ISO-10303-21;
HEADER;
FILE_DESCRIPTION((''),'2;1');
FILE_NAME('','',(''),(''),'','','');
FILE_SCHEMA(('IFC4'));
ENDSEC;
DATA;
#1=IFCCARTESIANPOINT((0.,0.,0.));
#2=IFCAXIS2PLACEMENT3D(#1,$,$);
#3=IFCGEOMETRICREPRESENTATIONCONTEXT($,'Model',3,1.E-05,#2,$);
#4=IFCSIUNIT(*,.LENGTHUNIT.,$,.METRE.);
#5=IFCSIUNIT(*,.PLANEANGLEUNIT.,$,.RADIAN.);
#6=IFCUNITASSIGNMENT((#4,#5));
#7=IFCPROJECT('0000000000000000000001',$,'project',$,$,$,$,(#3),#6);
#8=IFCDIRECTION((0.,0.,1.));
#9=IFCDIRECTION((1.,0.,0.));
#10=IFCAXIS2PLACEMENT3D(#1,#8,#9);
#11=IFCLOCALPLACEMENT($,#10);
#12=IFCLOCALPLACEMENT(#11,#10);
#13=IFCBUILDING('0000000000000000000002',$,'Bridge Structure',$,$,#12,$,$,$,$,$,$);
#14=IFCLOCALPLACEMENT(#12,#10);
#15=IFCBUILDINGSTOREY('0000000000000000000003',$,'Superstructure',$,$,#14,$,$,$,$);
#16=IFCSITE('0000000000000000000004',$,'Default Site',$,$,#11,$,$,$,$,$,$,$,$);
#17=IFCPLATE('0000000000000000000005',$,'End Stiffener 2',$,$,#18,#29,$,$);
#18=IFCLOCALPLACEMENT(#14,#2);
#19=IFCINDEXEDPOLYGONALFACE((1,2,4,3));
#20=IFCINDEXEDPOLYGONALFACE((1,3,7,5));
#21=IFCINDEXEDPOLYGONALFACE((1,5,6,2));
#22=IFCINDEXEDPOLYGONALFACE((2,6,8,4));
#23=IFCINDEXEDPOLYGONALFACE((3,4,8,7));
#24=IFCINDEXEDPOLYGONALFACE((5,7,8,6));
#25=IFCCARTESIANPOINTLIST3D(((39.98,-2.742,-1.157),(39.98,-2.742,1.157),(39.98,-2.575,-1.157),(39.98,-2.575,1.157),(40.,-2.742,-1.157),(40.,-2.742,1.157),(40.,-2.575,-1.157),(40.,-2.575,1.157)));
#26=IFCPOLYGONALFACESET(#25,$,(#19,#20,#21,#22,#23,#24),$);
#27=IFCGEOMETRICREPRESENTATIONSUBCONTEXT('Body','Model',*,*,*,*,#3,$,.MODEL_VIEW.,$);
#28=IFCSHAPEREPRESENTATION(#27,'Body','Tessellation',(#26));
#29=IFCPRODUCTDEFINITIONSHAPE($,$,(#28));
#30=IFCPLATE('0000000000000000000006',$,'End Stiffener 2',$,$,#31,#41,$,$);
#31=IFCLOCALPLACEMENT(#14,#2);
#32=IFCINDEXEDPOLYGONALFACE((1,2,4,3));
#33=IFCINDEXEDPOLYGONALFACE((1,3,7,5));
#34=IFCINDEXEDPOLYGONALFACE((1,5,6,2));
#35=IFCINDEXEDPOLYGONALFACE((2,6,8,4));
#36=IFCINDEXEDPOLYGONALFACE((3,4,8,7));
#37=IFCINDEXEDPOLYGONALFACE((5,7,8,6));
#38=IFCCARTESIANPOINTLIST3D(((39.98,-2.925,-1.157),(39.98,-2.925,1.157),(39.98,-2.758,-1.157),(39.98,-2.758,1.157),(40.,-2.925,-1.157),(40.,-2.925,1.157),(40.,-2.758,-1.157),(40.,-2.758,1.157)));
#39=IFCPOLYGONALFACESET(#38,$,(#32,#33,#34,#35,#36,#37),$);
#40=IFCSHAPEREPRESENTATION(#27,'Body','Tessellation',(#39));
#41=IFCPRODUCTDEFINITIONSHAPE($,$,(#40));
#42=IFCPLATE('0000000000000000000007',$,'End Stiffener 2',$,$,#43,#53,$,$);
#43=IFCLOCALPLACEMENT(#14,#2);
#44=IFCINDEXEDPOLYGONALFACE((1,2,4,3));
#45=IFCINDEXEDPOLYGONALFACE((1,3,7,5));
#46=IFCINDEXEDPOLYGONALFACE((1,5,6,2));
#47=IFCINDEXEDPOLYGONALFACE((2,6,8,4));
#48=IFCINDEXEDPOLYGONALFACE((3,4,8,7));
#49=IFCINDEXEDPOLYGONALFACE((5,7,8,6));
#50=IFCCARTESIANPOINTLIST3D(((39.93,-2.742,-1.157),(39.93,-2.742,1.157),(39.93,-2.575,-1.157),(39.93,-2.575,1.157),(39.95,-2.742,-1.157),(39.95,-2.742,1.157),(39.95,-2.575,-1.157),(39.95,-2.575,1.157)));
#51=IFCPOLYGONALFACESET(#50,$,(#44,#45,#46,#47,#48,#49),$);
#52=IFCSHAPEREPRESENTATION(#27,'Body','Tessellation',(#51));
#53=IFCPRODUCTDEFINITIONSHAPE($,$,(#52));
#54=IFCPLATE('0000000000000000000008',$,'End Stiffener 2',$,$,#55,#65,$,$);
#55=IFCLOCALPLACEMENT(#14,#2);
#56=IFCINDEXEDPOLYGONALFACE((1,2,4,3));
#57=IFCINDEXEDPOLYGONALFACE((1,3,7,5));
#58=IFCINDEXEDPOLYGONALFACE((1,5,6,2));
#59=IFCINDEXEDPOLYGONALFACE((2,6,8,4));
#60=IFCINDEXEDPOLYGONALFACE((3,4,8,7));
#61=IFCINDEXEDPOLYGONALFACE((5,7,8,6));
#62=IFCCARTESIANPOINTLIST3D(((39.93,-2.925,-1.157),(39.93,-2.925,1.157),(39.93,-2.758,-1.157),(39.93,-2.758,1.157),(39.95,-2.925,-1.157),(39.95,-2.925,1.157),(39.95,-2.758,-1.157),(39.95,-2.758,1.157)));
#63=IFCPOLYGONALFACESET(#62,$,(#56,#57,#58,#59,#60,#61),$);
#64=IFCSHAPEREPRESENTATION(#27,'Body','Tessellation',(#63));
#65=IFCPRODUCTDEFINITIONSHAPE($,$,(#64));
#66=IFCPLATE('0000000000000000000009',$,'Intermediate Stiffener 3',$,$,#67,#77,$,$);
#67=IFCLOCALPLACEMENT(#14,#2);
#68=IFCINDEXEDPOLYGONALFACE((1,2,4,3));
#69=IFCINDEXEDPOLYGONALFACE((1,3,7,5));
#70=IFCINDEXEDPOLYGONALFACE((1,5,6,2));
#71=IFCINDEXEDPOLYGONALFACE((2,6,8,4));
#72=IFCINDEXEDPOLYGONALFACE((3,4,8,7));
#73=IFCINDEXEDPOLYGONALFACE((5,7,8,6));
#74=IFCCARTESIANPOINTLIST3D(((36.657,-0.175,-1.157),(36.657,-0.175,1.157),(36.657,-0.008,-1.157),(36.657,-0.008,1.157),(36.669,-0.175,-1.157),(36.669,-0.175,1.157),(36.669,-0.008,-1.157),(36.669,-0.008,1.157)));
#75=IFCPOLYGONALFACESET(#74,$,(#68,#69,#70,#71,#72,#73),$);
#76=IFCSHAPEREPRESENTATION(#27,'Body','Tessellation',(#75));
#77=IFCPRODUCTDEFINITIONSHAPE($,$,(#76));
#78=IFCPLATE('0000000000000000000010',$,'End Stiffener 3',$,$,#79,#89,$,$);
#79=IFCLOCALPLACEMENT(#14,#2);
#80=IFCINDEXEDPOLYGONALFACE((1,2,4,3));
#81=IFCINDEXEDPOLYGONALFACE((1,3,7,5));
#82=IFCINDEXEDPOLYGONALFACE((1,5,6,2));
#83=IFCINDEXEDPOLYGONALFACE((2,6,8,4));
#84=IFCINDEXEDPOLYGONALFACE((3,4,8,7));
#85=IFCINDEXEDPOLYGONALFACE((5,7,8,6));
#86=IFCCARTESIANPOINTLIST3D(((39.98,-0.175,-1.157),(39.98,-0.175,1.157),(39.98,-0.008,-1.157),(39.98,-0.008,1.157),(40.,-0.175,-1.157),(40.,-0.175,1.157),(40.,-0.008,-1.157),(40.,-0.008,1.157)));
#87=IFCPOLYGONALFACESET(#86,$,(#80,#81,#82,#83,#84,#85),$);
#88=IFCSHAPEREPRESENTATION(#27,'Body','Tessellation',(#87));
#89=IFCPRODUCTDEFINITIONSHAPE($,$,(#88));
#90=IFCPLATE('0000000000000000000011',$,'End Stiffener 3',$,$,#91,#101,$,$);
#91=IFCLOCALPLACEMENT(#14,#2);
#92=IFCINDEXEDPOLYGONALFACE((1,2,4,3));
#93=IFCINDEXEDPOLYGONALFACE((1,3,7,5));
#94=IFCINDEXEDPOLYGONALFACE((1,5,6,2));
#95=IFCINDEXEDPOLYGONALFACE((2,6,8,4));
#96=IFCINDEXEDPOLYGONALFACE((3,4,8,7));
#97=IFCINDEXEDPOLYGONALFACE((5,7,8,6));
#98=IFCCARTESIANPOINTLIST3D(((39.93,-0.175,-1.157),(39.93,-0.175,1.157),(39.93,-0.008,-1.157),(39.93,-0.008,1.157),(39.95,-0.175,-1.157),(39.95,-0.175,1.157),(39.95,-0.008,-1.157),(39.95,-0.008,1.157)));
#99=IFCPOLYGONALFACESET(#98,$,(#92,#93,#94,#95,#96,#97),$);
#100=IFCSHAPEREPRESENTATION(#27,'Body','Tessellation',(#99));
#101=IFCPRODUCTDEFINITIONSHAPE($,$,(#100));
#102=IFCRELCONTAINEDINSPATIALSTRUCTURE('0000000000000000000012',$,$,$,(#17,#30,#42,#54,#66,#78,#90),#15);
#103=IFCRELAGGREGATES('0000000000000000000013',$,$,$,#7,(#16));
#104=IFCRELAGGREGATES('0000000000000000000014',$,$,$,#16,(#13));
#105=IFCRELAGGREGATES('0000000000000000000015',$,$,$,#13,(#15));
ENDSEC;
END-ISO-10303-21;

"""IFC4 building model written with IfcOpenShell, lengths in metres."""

from ifc_helpers import new_model, si_unit, frame, origin, origin_with_axes, origin_2d_with_axis, place, context, subcontext, project, spatial, rectangle, extrude, element, save


model = new_model("IFC4")

# Units and contexts
model_context = context("Model", 3, precision=1e-05, world=origin())
body_context = subcontext(model_context, "Body", "Model", "MODEL_VIEW")
ifc_project = project(units=[si_unit("LENGTHUNIT", "METRE"), si_unit("PLANEANGLEUNIT", "RADIAN")], contexts=[model_context])

# Site, building, storey
site_placement = place(None, origin_with_axes())
site = spatial("IfcSite", under=ifc_project, at=site_placement, Name="Default Site")
building_placement = place(site_placement, origin_with_axes())
building = spatial("IfcBuilding", under=site, at=building_placement, Name="Bridge Structure")
storey_placement = place(building_placement, origin_with_axes())
storey = spatial("IfcBuildingStorey", under=building, at=storey_placement, Name="Superstructure")

# Plates
for number, where, z_axis, x_axis, name in (
    (1, (39.99, -2.6585, -1.157), (0.0, 0.0, 1.0), (1.0, 0.0, 0.0), "End Stiffener 2"),
    (2, (39.99, -2.8415, -1.157), (0.0, 0.0, 1.0), (1.0, 0.0, 0.0), "End Stiffener 2"),
    (3, (39.94, -2.6585, -1.157), (0.0, 0.0, 1.0), (1.0, 0.0, 0.0), "End Stiffener 2"),
    (4, (39.94, -2.8415, -1.157), (0.0, 0.0, 1.0), (1.0, 0.0, 0.0), "End Stiffener 2"),
):
    element("IfcPlate", number, at=place(storey_placement, frame(where, z_axis=z_axis, x_axis=x_axis)), inside=storey, Name=name, context=body_context, shape_type="SweptSolid", body=[
        extrude(rectangle(XDim=0.02, YDim=0.167, at=origin_2d_with_axis()), origin_with_axes(), (0.0, 0.0, 1.0), 2.314),
    ])
plate_1_placement = place(storey_placement, frame((36.663, -0.0915, -1.157), z_axis=(0.0, 0.0, 1.0), x_axis=(1.0, 0.0, 0.0)))
element("IfcPlate", 5, at=plate_1_placement, inside=storey, Name="Intermediate Stiffener 3", context=body_context, shape_type="SweptSolid", body=[
    extrude(rectangle(XDim=0.012, YDim=0.167, at=origin_2d_with_axis()), origin_with_axes(), (0.0, 0.0, 1.0), 2.314),
])
for number, where, z_axis, x_axis, name in (
    (6, (39.99, -0.0915, -1.157), (0.0, 0.0, 1.0), (1.0, 0.0, 0.0), "End Stiffener 3"),
    (7, (39.94, -0.0915, -1.157), (0.0, 0.0, 1.0), (1.0, 0.0, 0.0), "End Stiffener 3"),
):
    element("IfcPlate", number, at=place(storey_placement, frame(where, z_axis=z_axis, x_axis=x_axis)), inside=storey, Name=name, context=body_context, shape_type="SweptSolid", body=[
        extrude(rectangle(XDim=0.02, YDim=0.167, at=origin_2d_with_axis()), origin_with_axes(), (0.0, 0.0, 1.0), 2.314),
    ])

save(model, "model.ifc")
